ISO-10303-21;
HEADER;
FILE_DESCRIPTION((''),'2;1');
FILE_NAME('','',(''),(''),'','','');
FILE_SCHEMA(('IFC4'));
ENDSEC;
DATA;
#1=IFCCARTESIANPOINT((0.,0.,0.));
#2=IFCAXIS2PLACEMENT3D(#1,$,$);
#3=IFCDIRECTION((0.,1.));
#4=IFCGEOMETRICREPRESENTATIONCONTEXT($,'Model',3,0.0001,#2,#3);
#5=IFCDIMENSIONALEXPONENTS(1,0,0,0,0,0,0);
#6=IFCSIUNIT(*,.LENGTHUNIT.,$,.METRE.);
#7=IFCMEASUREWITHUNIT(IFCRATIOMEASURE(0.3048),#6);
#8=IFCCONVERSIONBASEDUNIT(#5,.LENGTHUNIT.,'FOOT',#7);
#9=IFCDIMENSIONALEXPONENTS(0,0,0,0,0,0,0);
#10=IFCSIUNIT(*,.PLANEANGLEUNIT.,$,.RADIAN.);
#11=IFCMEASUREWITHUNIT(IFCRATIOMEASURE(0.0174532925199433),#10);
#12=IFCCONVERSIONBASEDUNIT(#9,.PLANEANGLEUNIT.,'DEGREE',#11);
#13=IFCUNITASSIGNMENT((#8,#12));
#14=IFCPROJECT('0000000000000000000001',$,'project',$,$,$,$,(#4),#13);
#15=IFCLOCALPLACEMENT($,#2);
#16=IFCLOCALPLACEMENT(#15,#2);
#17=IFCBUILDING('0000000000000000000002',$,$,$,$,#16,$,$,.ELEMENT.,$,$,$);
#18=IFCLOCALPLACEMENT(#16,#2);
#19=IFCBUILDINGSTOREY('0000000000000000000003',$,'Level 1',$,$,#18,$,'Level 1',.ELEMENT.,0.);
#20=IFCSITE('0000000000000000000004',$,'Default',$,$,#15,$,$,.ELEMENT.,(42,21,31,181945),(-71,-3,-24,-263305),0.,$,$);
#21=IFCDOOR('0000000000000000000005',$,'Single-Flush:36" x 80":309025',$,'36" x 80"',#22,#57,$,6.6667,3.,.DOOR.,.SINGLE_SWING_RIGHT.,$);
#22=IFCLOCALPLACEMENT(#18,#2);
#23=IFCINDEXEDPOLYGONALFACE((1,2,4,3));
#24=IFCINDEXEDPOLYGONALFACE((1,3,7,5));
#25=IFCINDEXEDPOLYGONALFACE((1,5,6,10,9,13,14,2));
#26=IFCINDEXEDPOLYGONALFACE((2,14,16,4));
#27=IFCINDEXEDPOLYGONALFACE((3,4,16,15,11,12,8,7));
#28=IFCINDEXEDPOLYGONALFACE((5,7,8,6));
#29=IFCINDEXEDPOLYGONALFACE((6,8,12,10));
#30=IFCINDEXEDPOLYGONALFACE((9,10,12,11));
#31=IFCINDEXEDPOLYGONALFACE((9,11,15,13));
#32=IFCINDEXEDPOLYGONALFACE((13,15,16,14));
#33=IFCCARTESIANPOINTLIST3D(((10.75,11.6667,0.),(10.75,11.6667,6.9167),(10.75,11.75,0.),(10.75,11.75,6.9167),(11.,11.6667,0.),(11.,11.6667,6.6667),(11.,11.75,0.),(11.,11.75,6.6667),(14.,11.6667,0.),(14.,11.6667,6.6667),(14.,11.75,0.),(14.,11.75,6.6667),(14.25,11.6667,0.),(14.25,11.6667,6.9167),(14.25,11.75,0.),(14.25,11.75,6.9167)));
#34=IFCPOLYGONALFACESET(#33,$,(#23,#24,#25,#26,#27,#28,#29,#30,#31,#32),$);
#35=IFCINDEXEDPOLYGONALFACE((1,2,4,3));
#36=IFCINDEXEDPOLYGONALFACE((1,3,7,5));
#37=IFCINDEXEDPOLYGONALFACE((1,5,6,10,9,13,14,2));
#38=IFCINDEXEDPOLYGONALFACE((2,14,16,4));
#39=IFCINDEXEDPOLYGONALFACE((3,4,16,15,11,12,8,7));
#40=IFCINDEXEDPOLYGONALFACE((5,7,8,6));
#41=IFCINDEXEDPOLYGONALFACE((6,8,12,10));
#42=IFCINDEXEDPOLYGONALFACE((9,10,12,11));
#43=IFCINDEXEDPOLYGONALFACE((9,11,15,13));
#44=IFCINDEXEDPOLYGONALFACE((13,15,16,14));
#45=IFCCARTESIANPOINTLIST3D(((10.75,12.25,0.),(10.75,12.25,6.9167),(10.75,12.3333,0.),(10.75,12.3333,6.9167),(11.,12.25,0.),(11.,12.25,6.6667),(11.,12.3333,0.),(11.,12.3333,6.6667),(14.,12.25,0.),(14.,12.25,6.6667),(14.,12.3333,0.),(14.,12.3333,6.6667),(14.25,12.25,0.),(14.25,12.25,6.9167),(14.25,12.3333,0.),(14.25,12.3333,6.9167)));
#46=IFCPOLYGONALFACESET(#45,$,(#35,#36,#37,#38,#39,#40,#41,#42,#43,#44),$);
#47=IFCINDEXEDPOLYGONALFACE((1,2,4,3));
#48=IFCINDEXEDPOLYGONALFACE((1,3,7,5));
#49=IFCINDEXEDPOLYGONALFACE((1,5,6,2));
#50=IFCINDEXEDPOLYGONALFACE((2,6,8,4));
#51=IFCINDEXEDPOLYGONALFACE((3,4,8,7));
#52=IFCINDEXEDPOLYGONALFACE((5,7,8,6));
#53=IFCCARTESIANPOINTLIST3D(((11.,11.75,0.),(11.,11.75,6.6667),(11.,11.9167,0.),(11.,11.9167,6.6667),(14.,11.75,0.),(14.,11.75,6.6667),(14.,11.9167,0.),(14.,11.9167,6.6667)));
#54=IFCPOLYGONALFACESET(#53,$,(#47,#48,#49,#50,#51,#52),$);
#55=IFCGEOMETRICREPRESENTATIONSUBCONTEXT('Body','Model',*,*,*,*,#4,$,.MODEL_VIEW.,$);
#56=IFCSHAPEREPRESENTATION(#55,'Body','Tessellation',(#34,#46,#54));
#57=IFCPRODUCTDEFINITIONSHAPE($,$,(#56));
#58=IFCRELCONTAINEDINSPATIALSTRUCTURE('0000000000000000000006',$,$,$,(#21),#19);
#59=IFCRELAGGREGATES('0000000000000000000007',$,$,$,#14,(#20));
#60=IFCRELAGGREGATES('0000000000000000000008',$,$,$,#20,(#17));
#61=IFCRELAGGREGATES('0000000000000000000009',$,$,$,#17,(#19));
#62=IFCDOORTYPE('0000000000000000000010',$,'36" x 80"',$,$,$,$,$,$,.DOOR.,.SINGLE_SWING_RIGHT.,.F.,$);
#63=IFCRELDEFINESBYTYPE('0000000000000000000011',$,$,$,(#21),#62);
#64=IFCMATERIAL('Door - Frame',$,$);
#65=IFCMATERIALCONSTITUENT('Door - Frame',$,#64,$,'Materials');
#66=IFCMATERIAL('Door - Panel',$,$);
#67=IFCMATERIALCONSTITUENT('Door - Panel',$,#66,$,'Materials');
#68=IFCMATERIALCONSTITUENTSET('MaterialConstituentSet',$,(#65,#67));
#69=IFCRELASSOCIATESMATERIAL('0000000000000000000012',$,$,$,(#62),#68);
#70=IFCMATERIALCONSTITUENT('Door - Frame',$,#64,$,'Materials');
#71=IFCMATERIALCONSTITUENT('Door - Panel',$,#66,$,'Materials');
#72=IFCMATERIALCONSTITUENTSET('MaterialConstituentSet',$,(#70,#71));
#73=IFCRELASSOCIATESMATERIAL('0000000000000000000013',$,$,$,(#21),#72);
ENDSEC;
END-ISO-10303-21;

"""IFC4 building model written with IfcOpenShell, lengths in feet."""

from ifc_helpers import new_model, entity, si_unit, converted_unit, direction, frame, origin, origin_2d_with_axis, place, context, subcontext, project, spatial, polyline, rectangle, outline, extrude, source, transform, mapped, material, constituent, constituent_set, type_object, type_shapes, element, save


model = new_model("IFC4")

# Units and contexts
model_context = context("Model", 3, precision=0.0001, world=origin(), true_north=direction((0.0, 1.0)))
body_context = subcontext(model_context, "Body", "Model", "MODEL_VIEW")
ifc_project = project(units=[converted_unit("LENGTHUNIT", "FOOT", entity("IfcRatioMeasure", 0.3048), si_unit("LENGTHUNIT", "METRE"), dimensions=[1, 0, 0, 0, 0, 0, 0]), converted_unit("PLANEANGLEUNIT", "DEGREE", entity("IfcRatioMeasure", 0.0174532925199433), si_unit("PLANEANGLEUNIT", "RADIAN"), dimensions=[0, 0, 0, 0, 0, 0, 0])], contexts=[model_context])

# Site, building, storey
site_placement = place(None, origin())
site = spatial("IfcSite", under=ifc_project, at=site_placement, Name="Default", CompositionType="ELEMENT", RefLatitude=(42, 21, 31, 181945), RefLongitude=(-71, -3, -24, -263305), RefElevation=0.0)
building_placement = place(site_placement, origin())
building = spatial("IfcBuilding", under=site, at=building_placement, CompositionType="ELEMENT")
storey_placement = place(building_placement, origin())
storey = spatial("IfcBuildingStorey", under=building, at=storey_placement, Name="Level 1", LongName="Level 1", CompositionType="ELEMENT", Elevation=0.0)

# Shared definitions
placement_1 = place(storey_placement, frame((10.25, 12.0, 0.0)))

# Door
ifc_material_1 = material(Name="Door - Frame")
ifc_constituent_1 = constituent(ifc_material_1, Name="Door - Frame", Category="Materials")
ifc_material_2 = material(Name="Door - Panel")
ifc_constituent_2 = constituent(ifc_material_2, Name="Door - Panel", Category="Materials")
ifc_constituent_set_1 = constituent_set(constituents=[ifc_constituent_1, ifc_constituent_2], Name="MaterialConstituentSet")
ifc_constituent_3 = constituent(ifc_material_1, Name="Door - Frame", Category="Materials")
ifc_constituent_4 = constituent(ifc_material_2, Name="Door - Panel", Category="Materials")
ifc_constituent_set_2 = constituent_set(constituents=[ifc_constituent_3, ifc_constituent_4], Name="MaterialConstituentSet")
door_type = type_object("IfcDoorType", Name="36\" x 80\"", OperationType="SINGLE_SWING_RIGHT", ParameterTakesPrecedence=False, PredefinedType="DOOR", material=ifc_constituent_set_2)
shared_shape = source(origin(), body_context, "Body", "SweptSolid", [
    extrude(outline(polyline([(-1.75, -3.5208), (1.75, -3.5208), (1.75, 3.3958), (1.5, 3.3958), (1.5, -3.2708), (-1.5, -3.2708), (-1.5, 3.3958), (-1.75, 3.3958), (-1.75, -3.5208)])), frame((1.5, 0.5, 3.3958), z_axis=(0.0, 1.0, 0.0), x_axis=(1.0, 0.0, 0.0)), (0.0, 0.0, 1.0), 0.0833),
    extrude(outline(polyline([(-3.5208, -1.75), (3.3958, -1.75), (3.3958, -1.5), (-3.2708, -1.5), (-3.2708, 1.5), (3.3958, 1.5), (3.3958, 1.75), (-3.5208, 1.75), (-3.5208, -1.75)])), frame((1.5, -0.0833, 3.3958), z_axis=(0.0, 1.0, 0.0), x_axis=(0.0, 0.0, -1.0)), (0.0, 0.0, 1.0), 0.0833),
    extrude(rectangle(XDim=0.1667, YDim=3.0, at=origin_2d_with_axis()), frame((1.5, 0.4167, 0.0), z_axis=(0.0, 0.0, 1.0), x_axis=(0.0, 1.0, 0.0)), (0.0, 0.0, 1.0), 6.6667),
])
type_shapes(door_type, [shared_shape])
placement_2 = place(placement_1, frame((3.75, 0.25, 0.0)))
door_placement = place(placement_2, frame((0.0, 0.0, 0.0), z_axis=(0.0, 0.0, 1.0), x_axis=(-1.0, 0.0, 0.0)))
element("IfcDoor", 1, at=door_placement, inside=storey, type_object=door_type, material=ifc_constituent_set_1, Name="Single-Flush:36\" x 80\":309025", ObjectType="36\" x 80\"", OperationType="SINGLE_SWING_RIGHT", OverallHeight=6.6667, OverallWidth=3.0, PredefinedType="DOOR", context=body_context, shape_type="MappedRepresentation", body=[
    mapped(shared_shape, transform((0.0, 0.0, 0.0), scale=1.0)),
])

save(model, "model.ifc")
